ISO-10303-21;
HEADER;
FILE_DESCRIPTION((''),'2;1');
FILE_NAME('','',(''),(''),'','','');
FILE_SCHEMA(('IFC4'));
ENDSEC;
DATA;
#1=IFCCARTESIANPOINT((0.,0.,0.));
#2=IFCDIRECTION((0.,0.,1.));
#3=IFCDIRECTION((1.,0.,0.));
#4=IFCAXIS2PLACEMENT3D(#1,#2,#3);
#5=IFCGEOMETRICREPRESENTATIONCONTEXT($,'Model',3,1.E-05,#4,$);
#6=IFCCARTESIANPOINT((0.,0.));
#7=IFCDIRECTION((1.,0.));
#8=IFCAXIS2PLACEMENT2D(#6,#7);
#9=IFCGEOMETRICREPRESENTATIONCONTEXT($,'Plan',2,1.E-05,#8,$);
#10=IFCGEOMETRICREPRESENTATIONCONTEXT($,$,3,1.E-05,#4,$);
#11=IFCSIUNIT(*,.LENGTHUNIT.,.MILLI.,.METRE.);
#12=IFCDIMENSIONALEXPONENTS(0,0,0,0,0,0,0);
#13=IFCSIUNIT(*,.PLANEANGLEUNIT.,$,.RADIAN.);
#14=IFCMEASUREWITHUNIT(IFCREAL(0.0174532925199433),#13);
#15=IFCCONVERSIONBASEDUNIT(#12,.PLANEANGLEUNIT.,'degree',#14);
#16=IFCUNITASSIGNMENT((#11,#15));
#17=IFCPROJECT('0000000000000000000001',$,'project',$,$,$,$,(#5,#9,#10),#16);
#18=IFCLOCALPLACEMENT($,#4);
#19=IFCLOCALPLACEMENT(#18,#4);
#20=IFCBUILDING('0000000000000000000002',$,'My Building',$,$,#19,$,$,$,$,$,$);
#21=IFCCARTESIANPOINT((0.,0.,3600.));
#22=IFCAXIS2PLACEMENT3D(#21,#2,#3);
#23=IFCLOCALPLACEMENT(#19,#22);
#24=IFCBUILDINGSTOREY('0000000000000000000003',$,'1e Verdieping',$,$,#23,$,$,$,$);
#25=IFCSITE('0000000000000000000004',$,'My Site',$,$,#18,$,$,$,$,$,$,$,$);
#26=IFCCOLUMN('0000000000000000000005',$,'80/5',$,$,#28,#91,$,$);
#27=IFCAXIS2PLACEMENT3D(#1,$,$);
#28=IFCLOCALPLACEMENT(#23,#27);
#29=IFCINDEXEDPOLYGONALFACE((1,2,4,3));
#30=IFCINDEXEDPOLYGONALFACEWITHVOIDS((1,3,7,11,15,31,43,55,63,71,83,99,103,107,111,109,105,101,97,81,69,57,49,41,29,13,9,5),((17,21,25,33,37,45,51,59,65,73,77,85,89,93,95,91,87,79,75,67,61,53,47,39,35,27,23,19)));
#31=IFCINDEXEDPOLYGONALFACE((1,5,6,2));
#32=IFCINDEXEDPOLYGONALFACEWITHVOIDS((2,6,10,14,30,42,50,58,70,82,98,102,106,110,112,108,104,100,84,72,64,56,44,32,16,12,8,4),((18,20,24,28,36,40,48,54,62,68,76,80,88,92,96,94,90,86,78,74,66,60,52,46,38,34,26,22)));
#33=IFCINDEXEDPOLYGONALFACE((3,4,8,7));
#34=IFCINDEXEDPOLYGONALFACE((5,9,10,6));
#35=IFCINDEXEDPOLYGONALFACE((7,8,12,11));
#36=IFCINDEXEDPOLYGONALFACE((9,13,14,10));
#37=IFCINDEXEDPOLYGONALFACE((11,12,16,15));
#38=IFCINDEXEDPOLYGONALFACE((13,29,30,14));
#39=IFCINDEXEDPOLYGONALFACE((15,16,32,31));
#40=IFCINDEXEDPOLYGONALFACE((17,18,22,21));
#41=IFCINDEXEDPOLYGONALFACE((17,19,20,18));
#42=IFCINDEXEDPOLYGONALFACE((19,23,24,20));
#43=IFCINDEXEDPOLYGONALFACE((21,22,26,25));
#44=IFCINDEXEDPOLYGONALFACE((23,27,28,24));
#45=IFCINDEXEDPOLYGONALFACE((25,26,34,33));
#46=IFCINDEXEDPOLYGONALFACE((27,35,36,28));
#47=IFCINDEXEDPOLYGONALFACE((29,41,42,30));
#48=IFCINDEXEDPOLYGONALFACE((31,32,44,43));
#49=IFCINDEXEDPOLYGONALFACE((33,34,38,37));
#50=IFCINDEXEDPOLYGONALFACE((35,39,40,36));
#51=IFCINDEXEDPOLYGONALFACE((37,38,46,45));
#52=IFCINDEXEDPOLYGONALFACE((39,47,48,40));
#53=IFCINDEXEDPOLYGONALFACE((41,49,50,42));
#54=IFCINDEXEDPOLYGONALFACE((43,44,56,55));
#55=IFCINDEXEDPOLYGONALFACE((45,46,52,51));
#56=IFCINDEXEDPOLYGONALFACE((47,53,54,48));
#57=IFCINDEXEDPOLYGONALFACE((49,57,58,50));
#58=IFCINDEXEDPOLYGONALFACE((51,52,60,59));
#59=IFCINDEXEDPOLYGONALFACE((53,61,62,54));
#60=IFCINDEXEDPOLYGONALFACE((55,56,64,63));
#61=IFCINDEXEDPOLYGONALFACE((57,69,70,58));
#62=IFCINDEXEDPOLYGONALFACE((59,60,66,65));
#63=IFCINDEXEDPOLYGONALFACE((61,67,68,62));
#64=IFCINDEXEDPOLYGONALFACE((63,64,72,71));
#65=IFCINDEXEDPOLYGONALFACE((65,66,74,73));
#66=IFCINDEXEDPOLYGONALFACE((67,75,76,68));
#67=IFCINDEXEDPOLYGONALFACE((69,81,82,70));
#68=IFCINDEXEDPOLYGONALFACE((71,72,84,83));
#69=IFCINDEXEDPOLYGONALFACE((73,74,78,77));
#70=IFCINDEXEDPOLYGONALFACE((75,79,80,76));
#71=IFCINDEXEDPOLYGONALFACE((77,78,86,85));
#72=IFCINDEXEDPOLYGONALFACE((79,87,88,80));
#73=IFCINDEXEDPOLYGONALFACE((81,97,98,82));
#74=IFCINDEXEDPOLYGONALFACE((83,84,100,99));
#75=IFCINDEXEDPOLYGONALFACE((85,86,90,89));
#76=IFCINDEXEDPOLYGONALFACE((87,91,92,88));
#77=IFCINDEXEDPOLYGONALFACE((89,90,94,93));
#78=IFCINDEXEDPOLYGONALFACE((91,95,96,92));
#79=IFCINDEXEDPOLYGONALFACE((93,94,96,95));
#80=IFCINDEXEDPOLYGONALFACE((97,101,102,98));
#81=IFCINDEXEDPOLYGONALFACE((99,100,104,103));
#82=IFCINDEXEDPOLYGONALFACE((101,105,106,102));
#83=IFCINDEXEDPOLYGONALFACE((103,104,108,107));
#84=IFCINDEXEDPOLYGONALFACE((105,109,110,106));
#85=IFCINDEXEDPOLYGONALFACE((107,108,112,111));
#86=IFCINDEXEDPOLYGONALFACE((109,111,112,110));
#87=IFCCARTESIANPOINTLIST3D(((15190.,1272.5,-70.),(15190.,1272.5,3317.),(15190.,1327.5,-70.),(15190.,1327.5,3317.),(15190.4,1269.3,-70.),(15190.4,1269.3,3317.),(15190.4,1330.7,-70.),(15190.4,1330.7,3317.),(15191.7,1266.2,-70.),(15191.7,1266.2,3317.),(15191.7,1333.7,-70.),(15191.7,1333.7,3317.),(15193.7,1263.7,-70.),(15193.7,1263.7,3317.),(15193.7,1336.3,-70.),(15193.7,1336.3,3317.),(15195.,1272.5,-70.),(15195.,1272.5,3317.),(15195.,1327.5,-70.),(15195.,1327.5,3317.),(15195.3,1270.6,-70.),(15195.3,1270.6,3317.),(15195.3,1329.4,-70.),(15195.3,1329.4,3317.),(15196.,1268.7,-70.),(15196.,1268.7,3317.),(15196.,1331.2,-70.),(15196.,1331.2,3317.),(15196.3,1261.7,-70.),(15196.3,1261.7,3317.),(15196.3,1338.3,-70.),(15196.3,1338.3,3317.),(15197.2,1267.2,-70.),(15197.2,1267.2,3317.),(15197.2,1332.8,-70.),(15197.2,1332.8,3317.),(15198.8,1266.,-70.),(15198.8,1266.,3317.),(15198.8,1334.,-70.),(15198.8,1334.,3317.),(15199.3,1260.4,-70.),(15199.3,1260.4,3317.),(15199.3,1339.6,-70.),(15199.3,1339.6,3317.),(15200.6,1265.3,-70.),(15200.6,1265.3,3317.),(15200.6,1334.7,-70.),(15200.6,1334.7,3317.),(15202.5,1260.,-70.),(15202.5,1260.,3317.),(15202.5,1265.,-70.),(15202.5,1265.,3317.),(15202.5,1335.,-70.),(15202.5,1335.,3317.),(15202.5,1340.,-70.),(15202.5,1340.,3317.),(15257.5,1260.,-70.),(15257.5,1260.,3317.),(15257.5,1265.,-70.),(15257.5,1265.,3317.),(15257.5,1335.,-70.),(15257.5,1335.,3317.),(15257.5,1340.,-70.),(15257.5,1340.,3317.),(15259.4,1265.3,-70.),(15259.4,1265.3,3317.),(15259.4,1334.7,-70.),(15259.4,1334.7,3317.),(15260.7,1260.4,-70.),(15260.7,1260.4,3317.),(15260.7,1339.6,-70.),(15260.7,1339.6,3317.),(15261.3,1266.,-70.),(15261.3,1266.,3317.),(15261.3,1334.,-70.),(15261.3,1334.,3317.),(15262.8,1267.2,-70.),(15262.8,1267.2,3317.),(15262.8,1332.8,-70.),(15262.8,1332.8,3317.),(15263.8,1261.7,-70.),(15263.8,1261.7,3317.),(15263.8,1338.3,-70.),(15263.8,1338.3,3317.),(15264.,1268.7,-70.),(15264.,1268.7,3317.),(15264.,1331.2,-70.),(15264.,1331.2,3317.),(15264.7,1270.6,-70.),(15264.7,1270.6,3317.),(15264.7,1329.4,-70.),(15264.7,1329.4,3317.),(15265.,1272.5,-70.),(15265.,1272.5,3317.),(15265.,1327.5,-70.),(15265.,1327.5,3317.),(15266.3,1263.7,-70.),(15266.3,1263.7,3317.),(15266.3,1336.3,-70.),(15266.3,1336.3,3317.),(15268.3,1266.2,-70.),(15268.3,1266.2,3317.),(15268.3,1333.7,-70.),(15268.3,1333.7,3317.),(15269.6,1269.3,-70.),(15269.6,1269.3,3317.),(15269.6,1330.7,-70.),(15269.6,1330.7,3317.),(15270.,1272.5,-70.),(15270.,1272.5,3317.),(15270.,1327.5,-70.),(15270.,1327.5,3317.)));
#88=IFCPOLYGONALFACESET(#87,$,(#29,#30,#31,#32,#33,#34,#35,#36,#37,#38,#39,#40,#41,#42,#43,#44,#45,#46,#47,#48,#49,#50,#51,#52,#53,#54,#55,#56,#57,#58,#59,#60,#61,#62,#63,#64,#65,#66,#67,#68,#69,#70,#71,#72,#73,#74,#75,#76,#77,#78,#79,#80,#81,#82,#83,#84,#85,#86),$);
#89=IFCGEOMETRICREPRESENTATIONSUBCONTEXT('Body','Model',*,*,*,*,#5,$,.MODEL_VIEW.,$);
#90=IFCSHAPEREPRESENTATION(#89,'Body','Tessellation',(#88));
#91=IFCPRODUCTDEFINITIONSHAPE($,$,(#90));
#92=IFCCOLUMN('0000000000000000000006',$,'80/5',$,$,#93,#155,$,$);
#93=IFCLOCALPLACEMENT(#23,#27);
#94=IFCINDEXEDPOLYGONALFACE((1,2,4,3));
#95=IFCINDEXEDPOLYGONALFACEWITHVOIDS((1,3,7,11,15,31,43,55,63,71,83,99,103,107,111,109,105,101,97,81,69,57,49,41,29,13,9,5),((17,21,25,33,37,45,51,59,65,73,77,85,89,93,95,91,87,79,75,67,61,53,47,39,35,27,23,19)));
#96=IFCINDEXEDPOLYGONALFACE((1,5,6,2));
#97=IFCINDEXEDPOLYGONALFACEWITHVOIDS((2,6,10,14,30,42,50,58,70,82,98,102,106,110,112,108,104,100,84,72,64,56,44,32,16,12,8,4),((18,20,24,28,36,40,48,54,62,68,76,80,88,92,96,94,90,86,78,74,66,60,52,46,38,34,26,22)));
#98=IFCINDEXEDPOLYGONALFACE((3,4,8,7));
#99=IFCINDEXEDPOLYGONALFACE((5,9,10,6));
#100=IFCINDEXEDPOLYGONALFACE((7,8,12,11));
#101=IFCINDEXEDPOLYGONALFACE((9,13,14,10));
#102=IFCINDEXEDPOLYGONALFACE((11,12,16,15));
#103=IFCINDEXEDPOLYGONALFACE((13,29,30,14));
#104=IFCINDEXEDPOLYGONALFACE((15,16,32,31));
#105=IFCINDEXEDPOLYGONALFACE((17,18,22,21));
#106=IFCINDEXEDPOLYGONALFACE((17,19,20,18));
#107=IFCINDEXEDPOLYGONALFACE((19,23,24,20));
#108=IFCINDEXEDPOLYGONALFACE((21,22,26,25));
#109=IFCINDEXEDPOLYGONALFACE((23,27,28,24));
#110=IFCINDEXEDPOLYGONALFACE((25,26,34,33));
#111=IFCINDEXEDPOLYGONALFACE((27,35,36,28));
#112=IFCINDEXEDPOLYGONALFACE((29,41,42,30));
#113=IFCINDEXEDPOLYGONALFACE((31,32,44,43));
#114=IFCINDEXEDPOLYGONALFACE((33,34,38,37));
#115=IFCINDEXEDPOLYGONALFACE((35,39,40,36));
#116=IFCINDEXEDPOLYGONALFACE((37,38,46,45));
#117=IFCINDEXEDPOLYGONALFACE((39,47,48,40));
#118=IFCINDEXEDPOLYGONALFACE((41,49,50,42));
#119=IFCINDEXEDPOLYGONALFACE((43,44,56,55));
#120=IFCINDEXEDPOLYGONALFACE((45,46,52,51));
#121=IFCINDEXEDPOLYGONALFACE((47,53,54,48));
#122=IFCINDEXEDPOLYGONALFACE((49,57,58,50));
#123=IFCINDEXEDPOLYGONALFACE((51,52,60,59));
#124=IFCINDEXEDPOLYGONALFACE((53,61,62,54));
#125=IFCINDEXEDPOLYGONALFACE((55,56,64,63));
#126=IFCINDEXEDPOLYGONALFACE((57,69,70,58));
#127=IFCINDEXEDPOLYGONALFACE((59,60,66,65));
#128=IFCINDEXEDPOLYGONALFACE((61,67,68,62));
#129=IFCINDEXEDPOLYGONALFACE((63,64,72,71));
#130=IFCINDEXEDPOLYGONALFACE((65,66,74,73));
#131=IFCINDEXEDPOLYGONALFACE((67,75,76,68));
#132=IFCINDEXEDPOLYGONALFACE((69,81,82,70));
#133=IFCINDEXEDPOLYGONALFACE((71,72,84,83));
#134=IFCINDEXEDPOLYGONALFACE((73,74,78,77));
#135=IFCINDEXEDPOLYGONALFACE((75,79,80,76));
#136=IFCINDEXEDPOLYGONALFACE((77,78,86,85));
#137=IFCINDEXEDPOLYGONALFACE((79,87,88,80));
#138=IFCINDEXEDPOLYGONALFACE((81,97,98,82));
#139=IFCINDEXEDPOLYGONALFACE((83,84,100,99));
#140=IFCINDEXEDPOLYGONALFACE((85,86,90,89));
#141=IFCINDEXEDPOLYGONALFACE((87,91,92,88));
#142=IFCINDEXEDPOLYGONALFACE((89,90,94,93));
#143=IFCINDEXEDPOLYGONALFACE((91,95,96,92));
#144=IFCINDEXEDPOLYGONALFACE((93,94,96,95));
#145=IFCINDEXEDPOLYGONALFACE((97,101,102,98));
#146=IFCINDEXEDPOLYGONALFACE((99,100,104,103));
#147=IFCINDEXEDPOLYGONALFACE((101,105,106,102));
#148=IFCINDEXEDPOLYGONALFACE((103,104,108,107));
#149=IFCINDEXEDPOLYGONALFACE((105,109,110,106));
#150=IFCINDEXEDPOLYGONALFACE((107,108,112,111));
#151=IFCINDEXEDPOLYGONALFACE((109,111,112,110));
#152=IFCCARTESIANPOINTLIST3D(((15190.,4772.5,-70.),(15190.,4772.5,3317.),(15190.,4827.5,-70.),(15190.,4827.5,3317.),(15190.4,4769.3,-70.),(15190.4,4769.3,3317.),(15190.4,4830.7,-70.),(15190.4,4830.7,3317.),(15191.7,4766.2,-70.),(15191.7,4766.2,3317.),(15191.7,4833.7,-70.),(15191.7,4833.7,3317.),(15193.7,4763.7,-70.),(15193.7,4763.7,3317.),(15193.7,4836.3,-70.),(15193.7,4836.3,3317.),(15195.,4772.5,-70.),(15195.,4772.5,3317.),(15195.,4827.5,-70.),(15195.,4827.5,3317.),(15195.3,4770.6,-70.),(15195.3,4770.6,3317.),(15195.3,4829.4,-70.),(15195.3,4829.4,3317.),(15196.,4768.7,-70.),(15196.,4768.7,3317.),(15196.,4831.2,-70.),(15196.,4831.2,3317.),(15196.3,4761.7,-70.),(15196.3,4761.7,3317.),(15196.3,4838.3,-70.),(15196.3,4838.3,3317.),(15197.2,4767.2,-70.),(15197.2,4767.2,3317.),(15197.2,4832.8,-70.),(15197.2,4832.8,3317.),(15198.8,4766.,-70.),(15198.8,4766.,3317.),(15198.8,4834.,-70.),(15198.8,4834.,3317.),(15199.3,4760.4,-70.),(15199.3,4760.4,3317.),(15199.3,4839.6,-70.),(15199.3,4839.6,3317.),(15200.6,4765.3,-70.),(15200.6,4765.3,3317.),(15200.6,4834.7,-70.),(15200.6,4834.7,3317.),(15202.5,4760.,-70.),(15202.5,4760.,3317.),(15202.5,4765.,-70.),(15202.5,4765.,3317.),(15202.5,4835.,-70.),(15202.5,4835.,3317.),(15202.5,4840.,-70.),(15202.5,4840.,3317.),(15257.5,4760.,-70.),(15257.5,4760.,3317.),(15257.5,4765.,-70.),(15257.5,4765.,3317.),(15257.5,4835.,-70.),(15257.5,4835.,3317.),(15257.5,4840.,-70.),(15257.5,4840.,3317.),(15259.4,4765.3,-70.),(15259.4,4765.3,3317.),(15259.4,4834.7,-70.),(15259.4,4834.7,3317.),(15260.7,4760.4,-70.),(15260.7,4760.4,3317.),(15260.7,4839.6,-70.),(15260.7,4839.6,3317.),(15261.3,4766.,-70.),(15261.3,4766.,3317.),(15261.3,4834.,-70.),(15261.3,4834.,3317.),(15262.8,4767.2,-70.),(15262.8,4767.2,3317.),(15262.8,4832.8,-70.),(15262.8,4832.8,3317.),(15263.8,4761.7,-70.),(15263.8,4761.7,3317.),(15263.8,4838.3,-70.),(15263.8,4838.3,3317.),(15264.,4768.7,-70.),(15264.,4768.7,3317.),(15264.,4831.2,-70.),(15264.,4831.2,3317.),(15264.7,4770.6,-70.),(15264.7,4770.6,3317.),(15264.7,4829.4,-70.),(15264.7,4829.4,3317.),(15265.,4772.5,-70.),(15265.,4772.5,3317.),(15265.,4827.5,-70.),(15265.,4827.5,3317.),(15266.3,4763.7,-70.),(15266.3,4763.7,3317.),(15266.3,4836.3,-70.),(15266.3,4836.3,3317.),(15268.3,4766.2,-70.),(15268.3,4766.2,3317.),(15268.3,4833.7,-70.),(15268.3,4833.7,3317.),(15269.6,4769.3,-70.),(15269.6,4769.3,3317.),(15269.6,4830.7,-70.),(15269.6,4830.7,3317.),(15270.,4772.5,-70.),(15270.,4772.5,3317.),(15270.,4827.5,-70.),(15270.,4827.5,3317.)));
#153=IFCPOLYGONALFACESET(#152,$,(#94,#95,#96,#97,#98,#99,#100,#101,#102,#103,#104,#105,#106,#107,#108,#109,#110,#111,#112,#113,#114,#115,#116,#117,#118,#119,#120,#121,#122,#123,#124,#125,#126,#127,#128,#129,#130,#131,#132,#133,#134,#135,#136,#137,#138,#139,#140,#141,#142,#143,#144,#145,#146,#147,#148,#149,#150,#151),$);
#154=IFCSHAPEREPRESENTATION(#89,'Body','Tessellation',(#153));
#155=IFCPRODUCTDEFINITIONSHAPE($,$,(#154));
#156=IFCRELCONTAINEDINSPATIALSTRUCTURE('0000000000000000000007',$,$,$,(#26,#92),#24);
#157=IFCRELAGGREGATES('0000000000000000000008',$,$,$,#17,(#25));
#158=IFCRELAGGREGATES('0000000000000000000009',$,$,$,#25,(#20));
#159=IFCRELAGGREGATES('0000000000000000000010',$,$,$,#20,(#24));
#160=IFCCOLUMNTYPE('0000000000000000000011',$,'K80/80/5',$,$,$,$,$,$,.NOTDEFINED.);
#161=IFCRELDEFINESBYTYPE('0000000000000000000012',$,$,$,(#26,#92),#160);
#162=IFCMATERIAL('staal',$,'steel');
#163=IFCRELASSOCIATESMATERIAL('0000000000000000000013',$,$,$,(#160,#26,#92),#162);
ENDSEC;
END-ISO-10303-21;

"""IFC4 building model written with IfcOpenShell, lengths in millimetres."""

from ifc_helpers import new_model, entity, si_unit, converted_unit, frame, origin_with_axes, origin_2d_with_axis, place, context, subcontext, project, spatial, hollow_rectangle, extrude, material, material_profile, profile_set, profile_usage, type_object, element, save


model = new_model("IFC4")

# Units and contexts
model_context = context("Model", 3, precision=1e-05, world=origin_with_axes())
plan_context = context("Plan", 2, precision=1e-05, world=origin_2d_with_axis())
context_of_model = context(None, 3, precision=1e-05, world=origin_with_axes())
body_context = subcontext(model_context, "Body", "Model", "MODEL_VIEW")
ifc_project = project(units=[si_unit("LENGTHUNIT", "METRE", prefix="MILLI"), converted_unit("PLANEANGLEUNIT", "degree", entity("IfcReal", 0.0174532925199433), si_unit("PLANEANGLEUNIT", "RADIAN"), dimensions=[0, 0, 0, 0, 0, 0, 0])], contexts=[model_context, plan_context, context_of_model])

# Site, building, storey
site_placement = place(None, origin_with_axes())
site = spatial("IfcSite", under=ifc_project, at=site_placement, Name="My Site")
building_placement = place(site_placement, origin_with_axes())
building = spatial("IfcBuilding", under=site, at=building_placement, Name="My Building")
storey_placement = place(building_placement, frame((0.0, 0.0, 3600.0), z_axis=(0.0, 0.0, 1.0), x_axis=(1.0, 0.0, 0.0)))
storey = spatial("IfcBuildingStorey", under=building, at=storey_placement, Name="1e Verdieping")

# Columns
ifc_material_1 = material(Name="staal", Category="steel")
ifc_material_profile_1 = material_profile(ifc_material_1, hollow_rectangle(XDim=80.0, YDim=80.0, WallThickness=5.0, InnerFilletRadius=7.5, OuterFilletRadius=12.5))
ifc_profile_set_1 = profile_set([ifc_material_profile_1], Name="K80/80/5")
ifc_profile_usage_1 = profile_usage(ifc_profile_set_1)
column_type_1 = type_object("IfcColumnType", Name="K80/80/5", PredefinedType="NOTDEFINED", material=ifc_profile_set_1)
column_1_placement = place(storey_placement, frame((15230.0, 1300.0, -70.0), z_axis=(0.0, 0.0, 1.0), x_axis=(1.0, 0.0, 0.0)))
element("IfcColumn", 1, at=column_1_placement, inside=storey, type_object=column_type_1, material=ifc_profile_usage_1, Name="80/5", context=body_context, shape_type="SweptSolid", body=[
    extrude(hollow_rectangle(XDim=80.0, YDim=80.0, WallThickness=5.0, InnerFilletRadius=7.5, OuterFilletRadius=12.5), origin_with_axes(), (0.0, 0.0, 1.0), 3387.0),
])
ifc_profile_usage_2 = profile_usage(ifc_profile_set_1)
column_2_placement = place(storey_placement, frame((15230.0, 4800.0, -70.0), z_axis=(0.0, 0.0, 1.0), x_axis=(1.0, 0.0, 0.0)))
element("IfcColumn", 2, at=column_2_placement, inside=storey, type_object=column_type_1, material=ifc_profile_usage_2, Name="80/5", context=body_context, shape_type="SweptSolid", body=[
    extrude(hollow_rectangle(XDim=80.0, YDim=80.0, WallThickness=5.0, InnerFilletRadius=7.5, OuterFilletRadius=12.5), origin_with_axes(), (0.0, 0.0, 1.0), 3387.0),
])

save(model, "model.ifc")
